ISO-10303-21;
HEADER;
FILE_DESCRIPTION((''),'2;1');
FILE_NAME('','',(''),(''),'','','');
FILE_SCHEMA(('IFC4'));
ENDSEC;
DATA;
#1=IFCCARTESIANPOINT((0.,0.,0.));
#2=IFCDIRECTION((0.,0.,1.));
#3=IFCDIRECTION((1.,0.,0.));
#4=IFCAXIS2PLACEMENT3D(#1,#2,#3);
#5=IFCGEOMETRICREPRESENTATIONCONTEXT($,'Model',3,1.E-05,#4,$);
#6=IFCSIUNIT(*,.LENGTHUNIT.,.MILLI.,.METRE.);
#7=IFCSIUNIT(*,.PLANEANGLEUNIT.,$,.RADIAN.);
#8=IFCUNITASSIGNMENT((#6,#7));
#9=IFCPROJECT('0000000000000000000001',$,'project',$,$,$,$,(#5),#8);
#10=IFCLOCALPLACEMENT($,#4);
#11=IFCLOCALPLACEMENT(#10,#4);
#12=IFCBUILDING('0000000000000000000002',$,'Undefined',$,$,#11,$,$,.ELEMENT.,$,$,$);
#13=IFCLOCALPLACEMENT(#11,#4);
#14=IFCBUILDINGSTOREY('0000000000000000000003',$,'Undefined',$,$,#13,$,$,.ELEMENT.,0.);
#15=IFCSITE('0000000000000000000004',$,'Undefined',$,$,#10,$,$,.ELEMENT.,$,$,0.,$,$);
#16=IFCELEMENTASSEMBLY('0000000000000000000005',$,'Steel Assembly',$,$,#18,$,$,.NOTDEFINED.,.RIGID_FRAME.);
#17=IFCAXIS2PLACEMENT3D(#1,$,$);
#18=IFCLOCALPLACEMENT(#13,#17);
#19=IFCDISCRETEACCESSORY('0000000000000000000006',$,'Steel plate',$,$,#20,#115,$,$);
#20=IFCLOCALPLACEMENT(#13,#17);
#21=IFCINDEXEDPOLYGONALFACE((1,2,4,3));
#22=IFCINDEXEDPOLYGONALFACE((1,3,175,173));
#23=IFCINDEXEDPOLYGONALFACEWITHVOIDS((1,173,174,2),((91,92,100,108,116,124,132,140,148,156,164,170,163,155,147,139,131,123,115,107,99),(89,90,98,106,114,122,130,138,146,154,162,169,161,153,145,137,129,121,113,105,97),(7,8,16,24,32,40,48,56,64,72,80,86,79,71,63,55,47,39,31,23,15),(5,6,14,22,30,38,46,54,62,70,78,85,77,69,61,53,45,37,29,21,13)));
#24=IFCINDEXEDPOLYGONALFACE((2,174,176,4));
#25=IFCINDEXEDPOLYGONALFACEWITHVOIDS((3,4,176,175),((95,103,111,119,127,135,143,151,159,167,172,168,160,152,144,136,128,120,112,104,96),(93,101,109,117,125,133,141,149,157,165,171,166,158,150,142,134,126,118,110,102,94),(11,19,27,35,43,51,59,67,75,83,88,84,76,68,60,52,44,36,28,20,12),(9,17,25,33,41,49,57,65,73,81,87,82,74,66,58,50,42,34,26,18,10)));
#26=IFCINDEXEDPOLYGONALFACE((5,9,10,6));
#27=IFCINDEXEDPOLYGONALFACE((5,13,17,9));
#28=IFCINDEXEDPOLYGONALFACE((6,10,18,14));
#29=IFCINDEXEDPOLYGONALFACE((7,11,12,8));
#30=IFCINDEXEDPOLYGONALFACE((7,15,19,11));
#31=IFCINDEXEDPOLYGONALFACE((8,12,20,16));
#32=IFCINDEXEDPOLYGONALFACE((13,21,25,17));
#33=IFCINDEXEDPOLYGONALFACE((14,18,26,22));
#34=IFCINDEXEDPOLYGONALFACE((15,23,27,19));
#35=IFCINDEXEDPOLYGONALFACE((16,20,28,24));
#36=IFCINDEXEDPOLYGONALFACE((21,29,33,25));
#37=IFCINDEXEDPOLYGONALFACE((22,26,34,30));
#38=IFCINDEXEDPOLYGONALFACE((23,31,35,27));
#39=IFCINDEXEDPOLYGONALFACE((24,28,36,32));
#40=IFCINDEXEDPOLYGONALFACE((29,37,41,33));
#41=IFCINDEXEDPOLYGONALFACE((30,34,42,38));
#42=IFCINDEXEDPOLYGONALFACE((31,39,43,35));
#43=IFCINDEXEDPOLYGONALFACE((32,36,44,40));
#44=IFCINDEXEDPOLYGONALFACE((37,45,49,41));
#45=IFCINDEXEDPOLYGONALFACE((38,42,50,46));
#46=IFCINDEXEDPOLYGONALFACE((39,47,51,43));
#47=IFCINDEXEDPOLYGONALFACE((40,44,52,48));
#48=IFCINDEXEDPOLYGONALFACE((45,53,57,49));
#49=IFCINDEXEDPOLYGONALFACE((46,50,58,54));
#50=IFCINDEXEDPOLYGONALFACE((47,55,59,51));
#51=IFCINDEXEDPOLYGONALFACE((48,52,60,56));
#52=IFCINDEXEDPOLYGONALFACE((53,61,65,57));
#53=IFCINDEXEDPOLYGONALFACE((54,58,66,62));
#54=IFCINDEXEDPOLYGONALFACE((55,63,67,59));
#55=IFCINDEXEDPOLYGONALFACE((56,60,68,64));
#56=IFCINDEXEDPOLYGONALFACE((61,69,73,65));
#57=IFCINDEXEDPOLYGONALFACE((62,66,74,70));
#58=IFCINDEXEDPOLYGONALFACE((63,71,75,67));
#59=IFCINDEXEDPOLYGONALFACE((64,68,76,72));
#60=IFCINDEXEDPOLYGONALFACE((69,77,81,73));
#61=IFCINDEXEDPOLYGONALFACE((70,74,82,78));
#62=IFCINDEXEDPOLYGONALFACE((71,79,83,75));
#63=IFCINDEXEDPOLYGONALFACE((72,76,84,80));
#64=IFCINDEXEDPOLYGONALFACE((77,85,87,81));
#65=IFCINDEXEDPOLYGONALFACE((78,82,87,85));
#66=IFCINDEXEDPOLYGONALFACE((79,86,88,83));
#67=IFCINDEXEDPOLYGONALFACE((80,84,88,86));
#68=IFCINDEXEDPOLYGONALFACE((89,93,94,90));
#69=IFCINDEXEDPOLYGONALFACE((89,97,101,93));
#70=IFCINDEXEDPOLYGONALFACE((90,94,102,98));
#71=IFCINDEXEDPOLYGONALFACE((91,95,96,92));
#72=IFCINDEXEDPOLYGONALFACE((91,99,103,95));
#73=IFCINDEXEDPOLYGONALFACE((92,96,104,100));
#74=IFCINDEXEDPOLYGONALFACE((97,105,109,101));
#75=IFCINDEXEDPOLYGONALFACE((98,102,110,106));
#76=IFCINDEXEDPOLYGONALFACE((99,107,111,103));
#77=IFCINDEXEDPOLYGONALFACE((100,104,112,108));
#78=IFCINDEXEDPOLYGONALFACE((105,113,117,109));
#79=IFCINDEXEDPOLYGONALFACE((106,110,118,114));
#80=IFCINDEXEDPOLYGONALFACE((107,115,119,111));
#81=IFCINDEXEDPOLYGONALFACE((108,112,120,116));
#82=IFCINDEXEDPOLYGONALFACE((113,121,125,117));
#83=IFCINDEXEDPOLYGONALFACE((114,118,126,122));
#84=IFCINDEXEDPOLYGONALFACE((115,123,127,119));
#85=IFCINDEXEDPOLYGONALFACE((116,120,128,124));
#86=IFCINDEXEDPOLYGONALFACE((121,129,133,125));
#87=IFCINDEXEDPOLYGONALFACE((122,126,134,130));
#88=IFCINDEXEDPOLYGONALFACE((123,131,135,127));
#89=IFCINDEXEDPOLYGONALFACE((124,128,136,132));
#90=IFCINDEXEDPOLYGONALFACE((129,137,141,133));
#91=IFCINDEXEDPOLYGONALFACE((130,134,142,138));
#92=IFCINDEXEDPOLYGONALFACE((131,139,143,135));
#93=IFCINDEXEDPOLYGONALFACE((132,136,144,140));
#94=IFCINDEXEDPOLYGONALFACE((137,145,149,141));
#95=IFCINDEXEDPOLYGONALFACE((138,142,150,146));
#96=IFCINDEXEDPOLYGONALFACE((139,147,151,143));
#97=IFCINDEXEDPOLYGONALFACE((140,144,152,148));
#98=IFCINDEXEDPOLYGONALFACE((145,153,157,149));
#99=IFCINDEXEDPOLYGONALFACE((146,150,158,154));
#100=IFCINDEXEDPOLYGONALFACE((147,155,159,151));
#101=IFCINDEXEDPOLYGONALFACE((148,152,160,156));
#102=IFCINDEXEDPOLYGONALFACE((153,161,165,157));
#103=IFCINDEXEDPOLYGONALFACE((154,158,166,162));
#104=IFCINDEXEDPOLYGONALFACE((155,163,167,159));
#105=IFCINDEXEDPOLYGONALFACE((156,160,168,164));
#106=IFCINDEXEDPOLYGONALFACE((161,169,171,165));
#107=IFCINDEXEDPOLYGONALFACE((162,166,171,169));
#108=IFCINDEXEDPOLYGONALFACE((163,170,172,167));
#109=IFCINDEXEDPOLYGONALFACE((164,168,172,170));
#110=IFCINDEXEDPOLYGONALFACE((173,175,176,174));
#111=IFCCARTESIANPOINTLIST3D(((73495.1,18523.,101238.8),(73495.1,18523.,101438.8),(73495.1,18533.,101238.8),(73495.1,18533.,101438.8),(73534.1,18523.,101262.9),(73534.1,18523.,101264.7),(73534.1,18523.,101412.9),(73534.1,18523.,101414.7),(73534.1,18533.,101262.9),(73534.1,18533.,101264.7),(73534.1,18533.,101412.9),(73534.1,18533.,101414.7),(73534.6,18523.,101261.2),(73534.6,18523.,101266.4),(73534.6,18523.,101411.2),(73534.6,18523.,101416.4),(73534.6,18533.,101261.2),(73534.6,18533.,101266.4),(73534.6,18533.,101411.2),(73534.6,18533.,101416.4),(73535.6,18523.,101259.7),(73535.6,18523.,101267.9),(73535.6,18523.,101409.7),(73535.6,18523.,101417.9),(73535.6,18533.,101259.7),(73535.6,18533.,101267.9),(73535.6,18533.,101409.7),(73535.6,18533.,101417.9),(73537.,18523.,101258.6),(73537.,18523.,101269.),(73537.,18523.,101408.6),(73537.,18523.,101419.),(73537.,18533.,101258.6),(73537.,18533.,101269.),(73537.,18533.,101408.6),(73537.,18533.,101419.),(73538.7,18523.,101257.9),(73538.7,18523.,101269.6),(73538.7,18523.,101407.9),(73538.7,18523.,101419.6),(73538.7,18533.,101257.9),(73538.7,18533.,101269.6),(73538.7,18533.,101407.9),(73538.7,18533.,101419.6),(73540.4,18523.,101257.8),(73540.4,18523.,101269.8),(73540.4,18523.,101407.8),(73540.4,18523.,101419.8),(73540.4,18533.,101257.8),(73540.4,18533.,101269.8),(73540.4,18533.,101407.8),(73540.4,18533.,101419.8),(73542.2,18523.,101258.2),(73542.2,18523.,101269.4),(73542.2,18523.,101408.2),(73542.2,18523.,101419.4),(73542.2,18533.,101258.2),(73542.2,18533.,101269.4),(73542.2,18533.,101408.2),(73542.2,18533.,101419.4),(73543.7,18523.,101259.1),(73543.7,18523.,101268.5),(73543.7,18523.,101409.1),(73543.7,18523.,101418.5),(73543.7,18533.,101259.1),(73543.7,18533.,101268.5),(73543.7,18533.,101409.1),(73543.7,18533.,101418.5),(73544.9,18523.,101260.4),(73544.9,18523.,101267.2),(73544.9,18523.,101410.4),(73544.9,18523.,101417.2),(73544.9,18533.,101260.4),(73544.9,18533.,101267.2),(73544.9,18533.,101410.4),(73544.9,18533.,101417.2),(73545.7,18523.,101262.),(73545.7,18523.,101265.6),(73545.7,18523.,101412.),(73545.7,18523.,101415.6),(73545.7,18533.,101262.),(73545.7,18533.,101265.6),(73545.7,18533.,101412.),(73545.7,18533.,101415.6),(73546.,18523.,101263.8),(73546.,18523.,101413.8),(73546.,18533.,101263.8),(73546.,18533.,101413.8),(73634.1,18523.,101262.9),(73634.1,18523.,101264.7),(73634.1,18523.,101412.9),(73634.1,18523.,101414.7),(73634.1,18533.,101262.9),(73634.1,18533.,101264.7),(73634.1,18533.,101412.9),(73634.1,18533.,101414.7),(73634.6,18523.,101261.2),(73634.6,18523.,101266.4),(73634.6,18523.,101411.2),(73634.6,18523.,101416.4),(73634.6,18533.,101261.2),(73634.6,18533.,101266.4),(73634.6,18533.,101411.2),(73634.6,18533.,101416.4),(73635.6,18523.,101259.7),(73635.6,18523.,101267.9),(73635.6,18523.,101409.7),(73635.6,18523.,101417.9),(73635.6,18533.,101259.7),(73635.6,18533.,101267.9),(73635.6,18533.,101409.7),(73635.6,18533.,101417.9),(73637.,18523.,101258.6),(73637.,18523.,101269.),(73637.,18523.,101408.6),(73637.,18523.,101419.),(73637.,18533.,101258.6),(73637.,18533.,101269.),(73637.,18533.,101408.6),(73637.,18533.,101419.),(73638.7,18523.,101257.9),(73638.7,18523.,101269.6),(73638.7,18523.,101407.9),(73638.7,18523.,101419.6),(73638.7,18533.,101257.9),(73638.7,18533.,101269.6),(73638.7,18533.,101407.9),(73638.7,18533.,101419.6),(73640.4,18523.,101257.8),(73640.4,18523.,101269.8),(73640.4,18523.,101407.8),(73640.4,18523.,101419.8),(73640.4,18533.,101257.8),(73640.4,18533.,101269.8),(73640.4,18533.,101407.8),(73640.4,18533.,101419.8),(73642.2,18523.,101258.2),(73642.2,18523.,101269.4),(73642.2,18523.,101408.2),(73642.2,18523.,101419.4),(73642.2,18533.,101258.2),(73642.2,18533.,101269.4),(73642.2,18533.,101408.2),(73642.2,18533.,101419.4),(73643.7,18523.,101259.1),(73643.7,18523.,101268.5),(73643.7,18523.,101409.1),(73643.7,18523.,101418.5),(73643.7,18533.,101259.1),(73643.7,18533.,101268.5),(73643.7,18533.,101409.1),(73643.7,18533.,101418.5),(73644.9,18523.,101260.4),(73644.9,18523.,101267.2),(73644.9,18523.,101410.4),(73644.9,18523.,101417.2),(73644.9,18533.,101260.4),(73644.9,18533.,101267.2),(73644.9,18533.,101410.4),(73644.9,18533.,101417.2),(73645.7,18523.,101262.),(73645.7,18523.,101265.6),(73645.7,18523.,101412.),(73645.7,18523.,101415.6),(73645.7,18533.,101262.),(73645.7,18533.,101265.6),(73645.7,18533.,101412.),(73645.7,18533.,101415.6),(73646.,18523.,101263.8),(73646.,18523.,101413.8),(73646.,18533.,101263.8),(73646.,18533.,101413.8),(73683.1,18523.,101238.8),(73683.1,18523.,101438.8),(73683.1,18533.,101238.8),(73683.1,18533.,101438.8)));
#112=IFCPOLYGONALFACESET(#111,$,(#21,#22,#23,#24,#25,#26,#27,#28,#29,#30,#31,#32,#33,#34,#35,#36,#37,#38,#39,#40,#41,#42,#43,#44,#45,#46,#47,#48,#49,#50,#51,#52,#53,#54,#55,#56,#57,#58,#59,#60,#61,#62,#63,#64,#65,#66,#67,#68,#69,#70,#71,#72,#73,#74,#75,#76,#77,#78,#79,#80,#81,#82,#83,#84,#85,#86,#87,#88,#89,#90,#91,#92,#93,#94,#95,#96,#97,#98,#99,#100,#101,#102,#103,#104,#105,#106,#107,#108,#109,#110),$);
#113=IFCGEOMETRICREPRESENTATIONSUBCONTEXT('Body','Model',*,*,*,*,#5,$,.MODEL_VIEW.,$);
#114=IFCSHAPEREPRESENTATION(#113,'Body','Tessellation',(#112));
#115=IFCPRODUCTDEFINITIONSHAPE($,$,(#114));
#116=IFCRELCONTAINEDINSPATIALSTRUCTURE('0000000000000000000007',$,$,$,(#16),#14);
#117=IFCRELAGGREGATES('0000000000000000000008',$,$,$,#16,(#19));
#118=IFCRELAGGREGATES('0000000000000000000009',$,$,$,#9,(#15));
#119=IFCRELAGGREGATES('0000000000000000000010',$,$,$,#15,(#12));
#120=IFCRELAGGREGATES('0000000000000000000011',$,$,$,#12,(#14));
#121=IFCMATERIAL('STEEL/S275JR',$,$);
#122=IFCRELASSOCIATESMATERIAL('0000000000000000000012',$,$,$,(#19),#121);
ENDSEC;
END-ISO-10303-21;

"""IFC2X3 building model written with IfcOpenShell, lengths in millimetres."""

from ifc_helpers import new_model, si_unit, frame, origin_with_axes, origin_2d_with_axis, place, context, subcontext, project, spatial, polyline, circle, outline, extrude, source, transform, mapped, material, element, aggregate, save


model = new_model("IFC2X3")

# Units and contexts
model_context = context("Model", 3, precision=1e-05, world=origin_with_axes())
body_context = subcontext(model_context, "Body", "Model", "MODEL_VIEW")
ifc_project = project(units=[si_unit("LENGTHUNIT", "METRE", prefix="MILLI"), si_unit("PLANEANGLEUNIT", "RADIAN")], contexts=[model_context])

# Site, building, storey
site_placement = place(None, origin_with_axes())
site = spatial("IfcSite", under=ifc_project, at=site_placement, Name="Undefined", CompositionType="ELEMENT", RefElevation=0.0)
building_placement = place(site_placement, origin_with_axes())
building = spatial("IfcBuilding", under=site, at=building_placement, Name="Undefined", CompositionType="ELEMENT")
storey_placement = place(building_placement, origin_with_axes())
storey = spatial("IfcBuildingStorey", under=building, at=storey_placement, Name="Undefined", CompositionType="ELEMENT", Elevation=0.0)

# Element assembly
assembly_1_placement = place(storey_placement, origin_with_axes())
assembly_1 = element("IfcElementAssembly", 1, at=assembly_1_placement, inside=storey, Name="Steel Assembly", AssemblyPlace="NOTDEFINED", PredefinedType="RIGID_FRAME")

# Discrete accessory, opening
ifc_material_1 = material(Name="STEEL/S275JR")
shared_shape_1 = source(origin_with_axes(), body_context, "Body", "SweptSolid", [
    extrude(circle(Radius=6.0, at=origin_2d_with_axis()), frame((0.0, -0.2, 0.0), z_axis=(0.0, 1.0, 0.0), x_axis=(1.0, 0.0, 0.0)), (0.0, 0.0, 1.0), 10.2),
])
discrete_accessory_1_placement = place(assembly_1_placement, frame((73683.1, 18528.0, 101438.8), z_axis=(0.0, -1.0, 0.0), x_axis=(-1.0, 0.0, 0.0)))
discrete_accessory_1 = element("IfcDiscreteAccessory", 2, at=discrete_accessory_1_placement, material=ifc_material_1, Name="Steel plate", context=body_context, shape_type="SweptSolid", body=[
    extrude(outline(polyline([(0.0, 0.0), (188.0, 0.0), (188.0, 200.0), (0.0, 200.0), (0.0, 0.0)])), frame((0.0, 0.0, -5.0), z_axis=(0.0, 0.0, 1.0), x_axis=(1.0, 0.0, 0.0)), (0.0, 0.0, 1.0), 10.0),
])
opening_1_placement = place(assembly_1_placement, frame((73540.0, 18523.1, 101338.8), z_axis=(0.0, 0.0, 1.0), x_axis=(1.0, 0.0, 0.0)))
element("IfcOpeningElement", 3, at=opening_1_placement, cuts=discrete_accessory_1, ObjectType="Opening", context=body_context, shape_type="MappedRepresentation", body=[
    mapped(shared_shape_1, transform((0.0, 0.0, -75.0))),
    mapped(shared_shape_1, transform((100.0, 0.0, -75.0))),
    mapped(shared_shape_1, transform((0.0, 0.0, 75.0))),
    mapped(shared_shape_1, transform((100.0, 0.0, 75.0))),
])

aggregate(assembly_1, [discrete_accessory_1])

save(model, "model.ifc")
